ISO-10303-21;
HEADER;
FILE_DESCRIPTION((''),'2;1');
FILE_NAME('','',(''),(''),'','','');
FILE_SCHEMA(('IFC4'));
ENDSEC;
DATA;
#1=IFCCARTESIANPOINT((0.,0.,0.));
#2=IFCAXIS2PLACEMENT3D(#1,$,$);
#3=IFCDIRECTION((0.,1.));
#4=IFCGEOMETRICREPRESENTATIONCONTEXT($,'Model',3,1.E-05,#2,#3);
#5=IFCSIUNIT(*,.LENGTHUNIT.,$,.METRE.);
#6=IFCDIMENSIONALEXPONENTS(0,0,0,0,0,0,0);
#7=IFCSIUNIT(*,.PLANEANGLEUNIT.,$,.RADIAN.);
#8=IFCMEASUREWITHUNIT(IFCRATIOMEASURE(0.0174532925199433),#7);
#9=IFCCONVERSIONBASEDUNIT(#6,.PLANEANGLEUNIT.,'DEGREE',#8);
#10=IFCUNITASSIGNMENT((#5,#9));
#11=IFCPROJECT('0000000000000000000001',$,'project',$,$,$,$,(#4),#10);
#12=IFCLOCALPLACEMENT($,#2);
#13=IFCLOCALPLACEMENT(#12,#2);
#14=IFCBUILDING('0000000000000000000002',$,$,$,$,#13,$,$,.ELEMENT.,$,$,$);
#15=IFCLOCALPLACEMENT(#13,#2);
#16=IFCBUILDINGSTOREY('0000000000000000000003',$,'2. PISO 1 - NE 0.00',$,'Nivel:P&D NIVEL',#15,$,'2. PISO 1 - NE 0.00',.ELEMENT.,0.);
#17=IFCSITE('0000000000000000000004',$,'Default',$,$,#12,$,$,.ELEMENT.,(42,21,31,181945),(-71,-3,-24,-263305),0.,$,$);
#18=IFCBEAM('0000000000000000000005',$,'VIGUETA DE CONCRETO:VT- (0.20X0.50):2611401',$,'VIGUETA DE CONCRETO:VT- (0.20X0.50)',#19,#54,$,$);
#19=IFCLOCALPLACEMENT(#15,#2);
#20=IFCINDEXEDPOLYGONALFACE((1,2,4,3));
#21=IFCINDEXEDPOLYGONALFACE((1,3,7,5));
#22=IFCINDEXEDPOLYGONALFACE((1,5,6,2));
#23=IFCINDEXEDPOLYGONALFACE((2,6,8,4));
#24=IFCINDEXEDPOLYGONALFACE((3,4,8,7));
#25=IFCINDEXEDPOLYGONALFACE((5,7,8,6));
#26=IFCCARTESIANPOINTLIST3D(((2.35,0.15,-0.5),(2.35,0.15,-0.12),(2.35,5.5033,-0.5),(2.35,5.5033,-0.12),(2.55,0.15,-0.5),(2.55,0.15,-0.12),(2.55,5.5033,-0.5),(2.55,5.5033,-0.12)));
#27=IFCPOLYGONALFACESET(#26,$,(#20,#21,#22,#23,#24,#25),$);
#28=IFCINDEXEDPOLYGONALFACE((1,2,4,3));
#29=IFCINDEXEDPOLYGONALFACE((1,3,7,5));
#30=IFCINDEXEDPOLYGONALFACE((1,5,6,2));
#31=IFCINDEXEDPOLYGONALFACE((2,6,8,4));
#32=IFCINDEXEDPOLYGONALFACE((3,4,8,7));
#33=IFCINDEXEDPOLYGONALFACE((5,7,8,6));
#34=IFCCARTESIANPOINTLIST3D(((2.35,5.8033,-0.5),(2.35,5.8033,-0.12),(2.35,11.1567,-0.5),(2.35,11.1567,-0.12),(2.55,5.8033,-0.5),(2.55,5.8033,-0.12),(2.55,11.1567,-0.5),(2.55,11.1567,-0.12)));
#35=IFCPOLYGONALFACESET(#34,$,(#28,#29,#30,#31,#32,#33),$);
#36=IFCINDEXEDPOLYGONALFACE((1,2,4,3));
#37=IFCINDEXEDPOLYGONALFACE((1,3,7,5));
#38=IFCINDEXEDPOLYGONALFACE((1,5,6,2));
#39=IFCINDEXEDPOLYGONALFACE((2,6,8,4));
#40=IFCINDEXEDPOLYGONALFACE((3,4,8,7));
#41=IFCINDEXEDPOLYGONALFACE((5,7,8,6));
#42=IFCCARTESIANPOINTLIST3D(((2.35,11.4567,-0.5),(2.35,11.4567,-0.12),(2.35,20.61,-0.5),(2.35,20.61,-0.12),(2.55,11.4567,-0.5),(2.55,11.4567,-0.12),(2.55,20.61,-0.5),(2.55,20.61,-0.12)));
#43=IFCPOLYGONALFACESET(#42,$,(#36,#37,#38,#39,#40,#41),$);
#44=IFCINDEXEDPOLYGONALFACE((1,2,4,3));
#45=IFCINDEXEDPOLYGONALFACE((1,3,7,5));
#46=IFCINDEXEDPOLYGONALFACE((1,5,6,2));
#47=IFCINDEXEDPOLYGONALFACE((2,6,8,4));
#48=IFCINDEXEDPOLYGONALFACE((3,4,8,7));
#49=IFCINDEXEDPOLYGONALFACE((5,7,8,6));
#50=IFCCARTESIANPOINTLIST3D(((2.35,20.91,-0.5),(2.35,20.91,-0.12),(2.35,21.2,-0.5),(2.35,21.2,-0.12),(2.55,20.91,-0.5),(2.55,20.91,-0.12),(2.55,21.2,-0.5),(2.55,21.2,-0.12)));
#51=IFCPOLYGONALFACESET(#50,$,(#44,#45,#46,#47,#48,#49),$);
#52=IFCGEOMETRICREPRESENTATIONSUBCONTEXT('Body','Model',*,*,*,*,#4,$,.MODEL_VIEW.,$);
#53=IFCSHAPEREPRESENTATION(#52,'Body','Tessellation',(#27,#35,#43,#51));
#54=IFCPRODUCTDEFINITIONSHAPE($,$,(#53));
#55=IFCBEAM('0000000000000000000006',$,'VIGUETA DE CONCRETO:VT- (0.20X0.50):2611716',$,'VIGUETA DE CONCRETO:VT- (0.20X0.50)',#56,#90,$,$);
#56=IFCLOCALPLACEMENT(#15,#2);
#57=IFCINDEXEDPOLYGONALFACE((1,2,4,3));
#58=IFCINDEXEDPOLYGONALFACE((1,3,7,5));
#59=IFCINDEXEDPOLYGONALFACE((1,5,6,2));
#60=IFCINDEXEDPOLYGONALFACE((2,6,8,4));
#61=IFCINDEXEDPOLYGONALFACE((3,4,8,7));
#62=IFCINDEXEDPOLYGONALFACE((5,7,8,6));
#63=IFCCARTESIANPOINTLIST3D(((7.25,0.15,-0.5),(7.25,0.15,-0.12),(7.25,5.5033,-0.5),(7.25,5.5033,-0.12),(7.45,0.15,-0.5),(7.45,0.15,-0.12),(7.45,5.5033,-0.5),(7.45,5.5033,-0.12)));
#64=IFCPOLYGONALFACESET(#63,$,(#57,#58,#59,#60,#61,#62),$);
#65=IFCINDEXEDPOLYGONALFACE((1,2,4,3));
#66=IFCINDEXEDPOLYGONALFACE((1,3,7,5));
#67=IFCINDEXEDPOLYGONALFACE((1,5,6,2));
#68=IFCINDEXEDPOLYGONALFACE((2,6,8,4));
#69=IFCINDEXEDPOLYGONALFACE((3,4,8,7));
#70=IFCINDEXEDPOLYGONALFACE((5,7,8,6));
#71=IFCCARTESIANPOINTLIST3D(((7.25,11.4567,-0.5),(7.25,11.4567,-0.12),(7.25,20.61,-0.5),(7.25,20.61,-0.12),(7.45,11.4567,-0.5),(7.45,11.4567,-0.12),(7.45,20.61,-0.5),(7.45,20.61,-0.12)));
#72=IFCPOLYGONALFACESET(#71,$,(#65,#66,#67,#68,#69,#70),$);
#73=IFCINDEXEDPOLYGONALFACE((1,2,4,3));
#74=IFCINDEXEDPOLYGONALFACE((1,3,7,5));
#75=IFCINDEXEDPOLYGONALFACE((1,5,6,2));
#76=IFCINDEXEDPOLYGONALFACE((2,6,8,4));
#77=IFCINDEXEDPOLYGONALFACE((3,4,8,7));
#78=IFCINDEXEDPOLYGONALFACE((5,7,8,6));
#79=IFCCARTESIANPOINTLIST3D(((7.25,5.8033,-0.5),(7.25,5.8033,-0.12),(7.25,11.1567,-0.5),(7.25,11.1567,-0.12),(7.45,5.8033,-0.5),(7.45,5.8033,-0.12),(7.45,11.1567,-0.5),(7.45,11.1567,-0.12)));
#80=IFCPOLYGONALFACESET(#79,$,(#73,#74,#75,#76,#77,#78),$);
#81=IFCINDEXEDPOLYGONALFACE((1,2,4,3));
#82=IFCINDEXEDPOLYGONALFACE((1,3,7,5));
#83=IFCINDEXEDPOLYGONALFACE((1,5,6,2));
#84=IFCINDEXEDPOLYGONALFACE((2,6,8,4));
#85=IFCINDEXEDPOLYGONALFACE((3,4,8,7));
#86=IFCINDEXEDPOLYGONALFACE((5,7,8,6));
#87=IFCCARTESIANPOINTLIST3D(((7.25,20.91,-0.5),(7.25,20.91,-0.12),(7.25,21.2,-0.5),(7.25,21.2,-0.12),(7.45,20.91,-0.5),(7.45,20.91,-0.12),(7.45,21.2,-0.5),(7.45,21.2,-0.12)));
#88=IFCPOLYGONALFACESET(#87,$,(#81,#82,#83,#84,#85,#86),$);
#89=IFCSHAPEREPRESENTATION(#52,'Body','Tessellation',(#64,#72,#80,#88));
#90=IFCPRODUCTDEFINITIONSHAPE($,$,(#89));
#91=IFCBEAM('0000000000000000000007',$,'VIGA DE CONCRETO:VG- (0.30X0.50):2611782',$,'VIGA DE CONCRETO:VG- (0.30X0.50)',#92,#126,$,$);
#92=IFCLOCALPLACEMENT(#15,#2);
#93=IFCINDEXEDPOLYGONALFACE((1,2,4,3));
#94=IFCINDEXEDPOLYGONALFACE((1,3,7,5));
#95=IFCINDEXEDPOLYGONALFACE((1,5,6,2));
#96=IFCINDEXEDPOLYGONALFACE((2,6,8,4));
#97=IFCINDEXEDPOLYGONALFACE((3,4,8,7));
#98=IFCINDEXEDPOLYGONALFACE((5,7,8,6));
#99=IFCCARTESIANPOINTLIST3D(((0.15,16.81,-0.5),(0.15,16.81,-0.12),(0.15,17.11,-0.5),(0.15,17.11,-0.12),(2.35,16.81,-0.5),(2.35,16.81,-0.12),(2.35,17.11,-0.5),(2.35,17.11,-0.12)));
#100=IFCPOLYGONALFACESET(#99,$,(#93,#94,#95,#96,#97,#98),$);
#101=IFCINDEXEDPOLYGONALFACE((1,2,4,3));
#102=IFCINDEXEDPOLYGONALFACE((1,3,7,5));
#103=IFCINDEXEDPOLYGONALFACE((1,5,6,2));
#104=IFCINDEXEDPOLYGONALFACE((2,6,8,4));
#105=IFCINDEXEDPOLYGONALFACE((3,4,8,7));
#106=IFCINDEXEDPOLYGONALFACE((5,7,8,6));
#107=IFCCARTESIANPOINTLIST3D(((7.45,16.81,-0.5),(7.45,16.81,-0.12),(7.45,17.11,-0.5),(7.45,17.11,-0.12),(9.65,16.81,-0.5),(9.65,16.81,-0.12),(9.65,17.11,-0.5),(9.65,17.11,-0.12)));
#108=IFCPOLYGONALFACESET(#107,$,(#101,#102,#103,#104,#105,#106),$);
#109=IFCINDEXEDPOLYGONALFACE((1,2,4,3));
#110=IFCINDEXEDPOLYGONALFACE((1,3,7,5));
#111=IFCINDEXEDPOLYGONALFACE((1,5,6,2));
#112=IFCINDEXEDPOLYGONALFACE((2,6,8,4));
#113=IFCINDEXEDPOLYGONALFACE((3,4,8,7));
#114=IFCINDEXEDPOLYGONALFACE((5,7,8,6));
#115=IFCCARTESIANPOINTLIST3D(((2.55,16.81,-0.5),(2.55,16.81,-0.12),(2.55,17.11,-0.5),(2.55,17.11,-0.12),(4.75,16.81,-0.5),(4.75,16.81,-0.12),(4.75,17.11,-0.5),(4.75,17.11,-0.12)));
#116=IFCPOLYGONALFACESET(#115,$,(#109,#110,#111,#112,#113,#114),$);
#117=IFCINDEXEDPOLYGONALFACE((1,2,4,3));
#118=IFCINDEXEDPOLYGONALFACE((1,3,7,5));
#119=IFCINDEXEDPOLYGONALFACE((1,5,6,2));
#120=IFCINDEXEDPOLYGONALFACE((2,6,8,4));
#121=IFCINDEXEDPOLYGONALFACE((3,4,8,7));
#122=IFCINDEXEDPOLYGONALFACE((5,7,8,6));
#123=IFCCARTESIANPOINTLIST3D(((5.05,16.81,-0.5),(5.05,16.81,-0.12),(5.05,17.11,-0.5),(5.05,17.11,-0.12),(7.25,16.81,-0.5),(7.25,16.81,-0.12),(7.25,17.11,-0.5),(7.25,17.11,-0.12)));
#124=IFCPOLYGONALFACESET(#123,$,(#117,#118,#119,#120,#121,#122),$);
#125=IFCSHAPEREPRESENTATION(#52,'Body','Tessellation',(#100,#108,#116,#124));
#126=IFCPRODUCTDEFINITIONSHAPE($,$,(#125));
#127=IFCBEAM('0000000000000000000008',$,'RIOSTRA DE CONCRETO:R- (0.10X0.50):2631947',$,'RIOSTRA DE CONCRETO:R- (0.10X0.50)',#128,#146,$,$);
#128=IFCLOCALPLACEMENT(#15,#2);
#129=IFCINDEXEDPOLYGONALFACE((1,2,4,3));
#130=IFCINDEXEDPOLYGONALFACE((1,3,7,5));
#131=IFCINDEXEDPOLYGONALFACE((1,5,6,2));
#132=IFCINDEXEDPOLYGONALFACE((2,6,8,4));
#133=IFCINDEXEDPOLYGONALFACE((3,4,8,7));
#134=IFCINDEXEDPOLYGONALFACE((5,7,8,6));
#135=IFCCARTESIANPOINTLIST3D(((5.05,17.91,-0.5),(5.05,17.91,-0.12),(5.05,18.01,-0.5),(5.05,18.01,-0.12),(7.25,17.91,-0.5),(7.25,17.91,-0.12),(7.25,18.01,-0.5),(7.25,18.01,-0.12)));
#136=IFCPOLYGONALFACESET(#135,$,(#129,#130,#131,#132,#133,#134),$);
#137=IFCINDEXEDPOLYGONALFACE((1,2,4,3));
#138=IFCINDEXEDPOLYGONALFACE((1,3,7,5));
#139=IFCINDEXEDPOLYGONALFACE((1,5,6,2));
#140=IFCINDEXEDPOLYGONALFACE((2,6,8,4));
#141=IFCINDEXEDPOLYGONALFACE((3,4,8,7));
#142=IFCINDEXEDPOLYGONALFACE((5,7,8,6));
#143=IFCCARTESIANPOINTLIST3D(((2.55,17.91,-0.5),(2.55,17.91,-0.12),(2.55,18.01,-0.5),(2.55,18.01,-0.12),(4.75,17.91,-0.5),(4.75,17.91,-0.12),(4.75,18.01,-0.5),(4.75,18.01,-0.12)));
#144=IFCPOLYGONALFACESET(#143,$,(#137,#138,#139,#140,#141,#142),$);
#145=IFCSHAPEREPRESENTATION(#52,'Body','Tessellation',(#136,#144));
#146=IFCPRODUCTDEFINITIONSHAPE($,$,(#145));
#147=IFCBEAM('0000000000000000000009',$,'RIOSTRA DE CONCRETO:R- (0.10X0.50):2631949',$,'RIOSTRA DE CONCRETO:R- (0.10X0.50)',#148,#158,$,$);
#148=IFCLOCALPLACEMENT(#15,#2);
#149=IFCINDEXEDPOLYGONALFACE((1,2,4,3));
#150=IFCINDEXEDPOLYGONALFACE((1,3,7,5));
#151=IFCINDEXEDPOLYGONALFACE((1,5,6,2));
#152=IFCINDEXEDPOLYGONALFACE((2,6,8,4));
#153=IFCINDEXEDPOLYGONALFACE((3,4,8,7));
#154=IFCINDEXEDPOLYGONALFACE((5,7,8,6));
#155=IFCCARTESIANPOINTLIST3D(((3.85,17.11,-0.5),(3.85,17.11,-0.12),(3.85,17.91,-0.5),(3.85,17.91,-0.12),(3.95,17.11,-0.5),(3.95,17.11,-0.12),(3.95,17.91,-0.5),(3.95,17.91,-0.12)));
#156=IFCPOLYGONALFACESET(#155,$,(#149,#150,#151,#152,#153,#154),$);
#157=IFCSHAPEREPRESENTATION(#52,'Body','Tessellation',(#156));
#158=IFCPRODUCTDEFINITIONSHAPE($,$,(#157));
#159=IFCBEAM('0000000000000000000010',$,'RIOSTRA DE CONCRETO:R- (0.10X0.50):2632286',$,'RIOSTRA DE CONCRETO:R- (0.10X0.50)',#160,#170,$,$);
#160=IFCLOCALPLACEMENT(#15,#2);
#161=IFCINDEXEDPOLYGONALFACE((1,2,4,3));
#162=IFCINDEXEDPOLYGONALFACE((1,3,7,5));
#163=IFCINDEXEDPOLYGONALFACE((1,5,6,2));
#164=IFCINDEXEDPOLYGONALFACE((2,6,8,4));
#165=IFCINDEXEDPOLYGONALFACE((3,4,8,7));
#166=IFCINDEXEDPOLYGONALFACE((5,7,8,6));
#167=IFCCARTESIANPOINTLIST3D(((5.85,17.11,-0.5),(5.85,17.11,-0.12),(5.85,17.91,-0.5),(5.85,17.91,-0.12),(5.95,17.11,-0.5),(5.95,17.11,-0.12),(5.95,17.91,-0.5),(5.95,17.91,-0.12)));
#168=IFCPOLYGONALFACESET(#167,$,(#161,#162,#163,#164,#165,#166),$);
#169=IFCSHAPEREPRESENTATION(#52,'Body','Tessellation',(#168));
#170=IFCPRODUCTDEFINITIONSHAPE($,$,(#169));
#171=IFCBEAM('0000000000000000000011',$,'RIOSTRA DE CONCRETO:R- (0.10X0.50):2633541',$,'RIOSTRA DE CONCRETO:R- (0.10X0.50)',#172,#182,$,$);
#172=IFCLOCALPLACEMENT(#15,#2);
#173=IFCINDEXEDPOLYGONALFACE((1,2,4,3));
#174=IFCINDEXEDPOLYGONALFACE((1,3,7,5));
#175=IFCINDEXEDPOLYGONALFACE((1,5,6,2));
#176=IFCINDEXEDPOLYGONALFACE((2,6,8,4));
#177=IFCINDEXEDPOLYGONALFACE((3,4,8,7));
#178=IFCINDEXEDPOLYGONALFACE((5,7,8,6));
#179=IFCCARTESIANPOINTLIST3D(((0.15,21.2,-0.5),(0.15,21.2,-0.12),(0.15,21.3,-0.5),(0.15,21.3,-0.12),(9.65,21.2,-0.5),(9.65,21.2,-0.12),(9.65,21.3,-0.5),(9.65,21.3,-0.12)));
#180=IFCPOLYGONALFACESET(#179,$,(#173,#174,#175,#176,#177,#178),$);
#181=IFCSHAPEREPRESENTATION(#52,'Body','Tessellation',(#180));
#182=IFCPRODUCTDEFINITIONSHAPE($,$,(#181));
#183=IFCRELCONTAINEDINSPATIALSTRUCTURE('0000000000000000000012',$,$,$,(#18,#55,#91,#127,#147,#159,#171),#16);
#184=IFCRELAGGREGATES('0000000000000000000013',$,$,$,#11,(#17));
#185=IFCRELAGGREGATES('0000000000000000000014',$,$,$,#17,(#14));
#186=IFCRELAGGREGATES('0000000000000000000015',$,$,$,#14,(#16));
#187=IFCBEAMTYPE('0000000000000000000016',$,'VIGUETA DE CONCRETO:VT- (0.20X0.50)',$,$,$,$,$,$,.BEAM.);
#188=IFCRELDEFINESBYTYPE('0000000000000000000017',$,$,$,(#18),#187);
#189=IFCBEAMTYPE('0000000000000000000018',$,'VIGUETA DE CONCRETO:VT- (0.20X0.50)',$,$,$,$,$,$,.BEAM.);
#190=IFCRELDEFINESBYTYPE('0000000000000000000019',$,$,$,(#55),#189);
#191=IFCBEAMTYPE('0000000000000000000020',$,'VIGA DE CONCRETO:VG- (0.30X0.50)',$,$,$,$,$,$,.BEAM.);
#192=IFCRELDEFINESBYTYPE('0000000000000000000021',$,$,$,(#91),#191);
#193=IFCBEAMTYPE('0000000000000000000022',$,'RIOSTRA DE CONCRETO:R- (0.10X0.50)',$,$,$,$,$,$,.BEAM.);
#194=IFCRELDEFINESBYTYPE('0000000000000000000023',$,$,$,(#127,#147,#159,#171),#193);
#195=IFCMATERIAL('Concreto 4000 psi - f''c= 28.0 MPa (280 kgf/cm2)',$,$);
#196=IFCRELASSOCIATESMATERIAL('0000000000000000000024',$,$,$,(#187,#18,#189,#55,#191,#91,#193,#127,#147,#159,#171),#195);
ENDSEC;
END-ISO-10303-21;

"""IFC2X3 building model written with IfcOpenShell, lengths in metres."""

from ifc_helpers import new_model, entity, si_unit, converted_unit, direction, frame, frame_2d, origin, place, context, subcontext, project, spatial, rectangle, extrude, source, transform, mapped, material, type_object, type_shapes, element, save


model = new_model("IFC2X3")

# Units and contexts
model_context = context("Model", 3, precision=1e-05, world=origin(), true_north=direction((0.0, 1.0)))
body_context = subcontext(model_context, "Body", "Model", "MODEL_VIEW")
ifc_project = project(units=[si_unit("LENGTHUNIT", "METRE"), converted_unit("PLANEANGLEUNIT", "DEGREE", entity("IfcRatioMeasure", 0.0174532925199433), si_unit("PLANEANGLEUNIT", "RADIAN"), dimensions=[0, 0, 0, 0, 0, 0, 0])], contexts=[model_context])

# Site, building, storey
site_placement = place(None, origin())
site = spatial("IfcSite", under=ifc_project, at=site_placement, Name="Default", CompositionType="ELEMENT", RefLatitude=(42, 21, 31, 181945), RefLongitude=(-71, -3, -24, -263305), RefElevation=0.0)
building_placement = place(site_placement, origin())
building = spatial("IfcBuilding", under=site, at=building_placement, CompositionType="ELEMENT")
storey_placement = place(building_placement, origin())
storey = spatial("IfcBuildingStorey", under=building, at=storey_placement, Name="2. PISO 1 - NE 0.00", ObjectType="Nivel:P&D NIVEL", LongName="2. PISO 1 - NE 0.00", CompositionType="ELEMENT", Elevation=0.0)

# Shared definitions
ifc_material = material(Name="Concreto 4000 psi - f'c= 28.0 MPa (280 kgf/cm2)")

# Beams
beam_type_1 = type_object("IfcBeamType", Name="VIGUETA DE CONCRETO:VT- (0.20X0.50)", PredefinedType="BEAM", material=ifc_material)
shared_shape_1 = source(origin(), body_context, "Body", "SweptSolid", [
    extrude(rectangle(XDim=0.38, YDim=0.2, at=frame_2d((0.0, 0.0), x_axis=(0.0, 1.0))), frame((2.45, 5.5033, -0.31), z_axis=(0.0, -1.0, 0.0), x_axis=(-1.0, 0.0, 0.0)), (0.0, 0.0, 1.0), 5.3533),
    extrude(rectangle(XDim=0.38, YDim=0.2, at=frame_2d((0.0, 0.0), x_axis=(0.0, 1.0))), frame((2.45, 11.1567, -0.31), z_axis=(0.0, -1.0, 0.0), x_axis=(-1.0, 0.0, 0.0)), (0.0, 0.0, 1.0), 5.3533),
    extrude(rectangle(XDim=0.38, YDim=0.2, at=frame_2d((0.0, 0.0), x_axis=(0.0, 1.0))), frame((2.45, 20.61, -0.31), z_axis=(0.0, -1.0, 0.0), x_axis=(-1.0, 0.0, 0.0)), (0.0, 0.0, 1.0), 9.1533),
    extrude(rectangle(XDim=0.38, YDim=0.2, at=frame_2d((0.0, 0.0), x_axis=(0.0, 1.0))), frame((2.45, 21.2, -0.31), z_axis=(0.0, -1.0, 0.0), x_axis=(-1.0, 0.0, 0.0)), (0.0, 0.0, 1.0), 0.29),
])
type_shapes(beam_type_1, [shared_shape_1])
beam_1_placement = place(storey_placement, origin())
element("IfcBeam", 1, at=beam_1_placement, inside=storey, type_object=beam_type_1, material=ifc_material, Name="VIGUETA DE CONCRETO:VT- (0.20X0.50):2611401", ObjectType="VIGUETA DE CONCRETO:VT- (0.20X0.50)", context=body_context, shape_type="MappedRepresentation", body=[
    mapped(shared_shape_1, transform((0.0, 0.0, 0.0), scale=1.0)),
])
beam_type_2 = type_object("IfcBeamType", Name="VIGUETA DE CONCRETO:VT- (0.20X0.50)", PredefinedType="BEAM", material=ifc_material)
shared_shape_2 = source(origin(), body_context, "Body", "SweptSolid", [
    extrude(rectangle(XDim=0.38, YDim=0.2, at=frame_2d((0.0, 0.0), x_axis=(0.0, 1.0))), frame((7.35, 5.5033, -0.31), z_axis=(0.0, -1.0, 0.0), x_axis=(-1.0, 0.0, 0.0)), (0.0, 0.0, 1.0), 5.3533),
    extrude(rectangle(XDim=0.38, YDim=0.2, at=frame_2d((0.0, 0.0), x_axis=(0.0, 1.0))), frame((7.35, 20.61, -0.31), z_axis=(0.0, -1.0, 0.0), x_axis=(-1.0, 0.0, 0.0)), (0.0, 0.0, 1.0), 9.1533),
    extrude(rectangle(XDim=0.38, YDim=0.2, at=frame_2d((0.0, 0.0), x_axis=(0.0, 1.0))), frame((7.35, 11.1567, -0.31), z_axis=(0.0, -1.0, 0.0), x_axis=(-1.0, 0.0, 0.0)), (0.0, 0.0, 1.0), 5.3533),
    extrude(rectangle(XDim=0.38, YDim=0.2, at=frame_2d((0.0, 0.0), x_axis=(0.0, 1.0))), frame((7.35, 21.2, -0.31), z_axis=(0.0, -1.0, 0.0), x_axis=(-1.0, 0.0, 0.0)), (0.0, 0.0, 1.0), 0.29),
])
type_shapes(beam_type_2, [shared_shape_2])
beam_2_placement = place(storey_placement, origin())
element("IfcBeam", 2, at=beam_2_placement, inside=storey, type_object=beam_type_2, material=ifc_material, Name="VIGUETA DE CONCRETO:VT- (0.20X0.50):2611716", ObjectType="VIGUETA DE CONCRETO:VT- (0.20X0.50)", context=body_context, shape_type="MappedRepresentation", body=[
    mapped(shared_shape_2, transform((0.0, 0.0, 0.0), scale=1.0)),
])
beam_type_3 = type_object("IfcBeamType", Name="VIGA DE CONCRETO:VG- (0.30X0.50)", PredefinedType="BEAM", material=ifc_material)
shared_shape_3 = source(origin(), body_context, "Body", "SweptSolid", [
    extrude(rectangle(XDim=0.38, YDim=0.3, at=frame_2d((0.0, 0.0), x_axis=(1.0, 0.0))), frame((0.15, 16.96, -0.31), z_axis=(1.0, 0.0, 0.0), x_axis=(0.0, 0.0, -1.0)), (0.0, 0.0, 1.0), 2.2),
    extrude(rectangle(XDim=0.38, YDim=0.3, at=frame_2d((0.0, 0.0), x_axis=(1.0, 0.0))), frame((7.45, 16.96, -0.31), z_axis=(1.0, 0.0, 0.0), x_axis=(0.0, 0.0, -1.0)), (0.0, 0.0, 1.0), 2.2),
    extrude(rectangle(XDim=0.38, YDim=0.3, at=frame_2d((0.0, 0.0), x_axis=(1.0, 0.0))), frame((2.55, 16.96, -0.31), z_axis=(1.0, 0.0, 0.0), x_axis=(0.0, 0.0, -1.0)), (0.0, 0.0, 1.0), 2.2),
    extrude(rectangle(XDim=0.38, YDim=0.3, at=frame_2d((0.0, 0.0), x_axis=(1.0, 0.0))), frame((5.05, 16.96, -0.31), z_axis=(1.0, 0.0, 0.0), x_axis=(0.0, 0.0, -1.0)), (0.0, 0.0, 1.0), 2.2),
])
type_shapes(beam_type_3, [shared_shape_3])
beam_3_placement = place(storey_placement, origin())
element("IfcBeam", 3, at=beam_3_placement, inside=storey, type_object=beam_type_3, material=ifc_material, Name="VIGA DE CONCRETO:VG- (0.30X0.50):2611782", ObjectType="VIGA DE CONCRETO:VG- (0.30X0.50)", context=body_context, shape_type="MappedRepresentation", body=[
    mapped(shared_shape_3, transform((0.0, 0.0, 0.0), scale=1.0)),
])
beam_type_4 = type_object("IfcBeamType", Name="RIOSTRA DE CONCRETO:R- (0.10X0.50)", PredefinedType="BEAM", material=ifc_material)
shared_shape_4 = source(origin(), body_context, "Body", "SweptSolid", [
    extrude(rectangle(XDim=0.38, YDim=0.1, at=frame_2d((0.0, 0.0), x_axis=(1.0, 0.0))), frame((5.05, 17.96, -0.31), z_axis=(1.0, 0.0, 0.0), x_axis=(0.0, 0.0, -1.0)), (0.0, 0.0, 1.0), 2.2),
    extrude(rectangle(XDim=0.38, YDim=0.1, at=frame_2d((0.0, 0.0), x_axis=(1.0, 0.0))), frame((2.55, 17.96, -0.31), z_axis=(1.0, 0.0, 0.0), x_axis=(0.0, 0.0, -1.0)), (0.0, 0.0, 1.0), 2.2),
])
type_shapes(beam_type_4, [shared_shape_4])
beam_4_placement = place(storey_placement, origin())
element("IfcBeam", 4, at=beam_4_placement, inside=storey, type_object=beam_type_4, material=ifc_material, Name="RIOSTRA DE CONCRETO:R- (0.10X0.50):2631947", ObjectType="RIOSTRA DE CONCRETO:R- (0.10X0.50)", context=body_context, shape_type="MappedRepresentation", body=[
    mapped(shared_shape_4, transform((0.0, 0.0, 0.0), scale=1.0)),
])
beam_5_placement = place(storey_placement, frame((3.9, 17.96, 0.0), z_axis=(0.0, 0.0, 1.0), x_axis=(0.0, -1.0, 0.0)))
element("IfcBeam", 5, at=beam_5_placement, inside=storey, type_object=beam_type_4, material=ifc_material, Name="RIOSTRA DE CONCRETO:R- (0.10X0.50):2631949", ObjectType="RIOSTRA DE CONCRETO:R- (0.10X0.50)", context=body_context, shape_type="SweptSolid", body=[
    extrude(rectangle(XDim=0.38, YDim=0.1, at=frame_2d((0.0, 0.0), x_axis=(1.0, 0.0))), frame((0.05, 0.0, -0.31), z_axis=(1.0, 0.0, 0.0), x_axis=(0.0, 0.0, -1.0)), (0.0, 0.0, 1.0), 0.8),
])
beam_6_placement = place(storey_placement, frame((5.9, 17.96, 0.0), z_axis=(0.0, 0.0, 1.0), x_axis=(0.0, -1.0, 0.0)))
element("IfcBeam", 6, at=beam_6_placement, inside=storey, type_object=beam_type_4, material=ifc_material, Name="RIOSTRA DE CONCRETO:R- (0.10X0.50):2632286", ObjectType="RIOSTRA DE CONCRETO:R- (0.10X0.50)", context=body_context, shape_type="SweptSolid", body=[
    extrude(rectangle(XDim=0.38, YDim=0.1, at=frame_2d((0.0, 0.0), x_axis=(1.0, 0.0))), frame((0.05, 0.0, -0.31), z_axis=(1.0, 0.0, 0.0), x_axis=(0.0, 0.0, -1.0)), (0.0, 0.0, 1.0), 0.8),
])
beam_7_placement = place(storey_placement, frame((0.0, 21.25, 0.0)))
element("IfcBeam", 7, at=beam_7_placement, inside=storey, type_object=beam_type_4, material=ifc_material, Name="RIOSTRA DE CONCRETO:R- (0.10X0.50):2633541", ObjectType="RIOSTRA DE CONCRETO:R- (0.10X0.50)", context=body_context, shape_type="SweptSolid", body=[
    extrude(rectangle(XDim=0.38, YDim=0.1, at=frame_2d((0.0, 0.0), x_axis=(1.0, 0.0))), frame((0.15, 0.0, -0.31), z_axis=(1.0, 0.0, 0.0), x_axis=(0.0, 0.0, -1.0)), (0.0, 0.0, 1.0), 9.5),
])

save(model, "model.ifc")
